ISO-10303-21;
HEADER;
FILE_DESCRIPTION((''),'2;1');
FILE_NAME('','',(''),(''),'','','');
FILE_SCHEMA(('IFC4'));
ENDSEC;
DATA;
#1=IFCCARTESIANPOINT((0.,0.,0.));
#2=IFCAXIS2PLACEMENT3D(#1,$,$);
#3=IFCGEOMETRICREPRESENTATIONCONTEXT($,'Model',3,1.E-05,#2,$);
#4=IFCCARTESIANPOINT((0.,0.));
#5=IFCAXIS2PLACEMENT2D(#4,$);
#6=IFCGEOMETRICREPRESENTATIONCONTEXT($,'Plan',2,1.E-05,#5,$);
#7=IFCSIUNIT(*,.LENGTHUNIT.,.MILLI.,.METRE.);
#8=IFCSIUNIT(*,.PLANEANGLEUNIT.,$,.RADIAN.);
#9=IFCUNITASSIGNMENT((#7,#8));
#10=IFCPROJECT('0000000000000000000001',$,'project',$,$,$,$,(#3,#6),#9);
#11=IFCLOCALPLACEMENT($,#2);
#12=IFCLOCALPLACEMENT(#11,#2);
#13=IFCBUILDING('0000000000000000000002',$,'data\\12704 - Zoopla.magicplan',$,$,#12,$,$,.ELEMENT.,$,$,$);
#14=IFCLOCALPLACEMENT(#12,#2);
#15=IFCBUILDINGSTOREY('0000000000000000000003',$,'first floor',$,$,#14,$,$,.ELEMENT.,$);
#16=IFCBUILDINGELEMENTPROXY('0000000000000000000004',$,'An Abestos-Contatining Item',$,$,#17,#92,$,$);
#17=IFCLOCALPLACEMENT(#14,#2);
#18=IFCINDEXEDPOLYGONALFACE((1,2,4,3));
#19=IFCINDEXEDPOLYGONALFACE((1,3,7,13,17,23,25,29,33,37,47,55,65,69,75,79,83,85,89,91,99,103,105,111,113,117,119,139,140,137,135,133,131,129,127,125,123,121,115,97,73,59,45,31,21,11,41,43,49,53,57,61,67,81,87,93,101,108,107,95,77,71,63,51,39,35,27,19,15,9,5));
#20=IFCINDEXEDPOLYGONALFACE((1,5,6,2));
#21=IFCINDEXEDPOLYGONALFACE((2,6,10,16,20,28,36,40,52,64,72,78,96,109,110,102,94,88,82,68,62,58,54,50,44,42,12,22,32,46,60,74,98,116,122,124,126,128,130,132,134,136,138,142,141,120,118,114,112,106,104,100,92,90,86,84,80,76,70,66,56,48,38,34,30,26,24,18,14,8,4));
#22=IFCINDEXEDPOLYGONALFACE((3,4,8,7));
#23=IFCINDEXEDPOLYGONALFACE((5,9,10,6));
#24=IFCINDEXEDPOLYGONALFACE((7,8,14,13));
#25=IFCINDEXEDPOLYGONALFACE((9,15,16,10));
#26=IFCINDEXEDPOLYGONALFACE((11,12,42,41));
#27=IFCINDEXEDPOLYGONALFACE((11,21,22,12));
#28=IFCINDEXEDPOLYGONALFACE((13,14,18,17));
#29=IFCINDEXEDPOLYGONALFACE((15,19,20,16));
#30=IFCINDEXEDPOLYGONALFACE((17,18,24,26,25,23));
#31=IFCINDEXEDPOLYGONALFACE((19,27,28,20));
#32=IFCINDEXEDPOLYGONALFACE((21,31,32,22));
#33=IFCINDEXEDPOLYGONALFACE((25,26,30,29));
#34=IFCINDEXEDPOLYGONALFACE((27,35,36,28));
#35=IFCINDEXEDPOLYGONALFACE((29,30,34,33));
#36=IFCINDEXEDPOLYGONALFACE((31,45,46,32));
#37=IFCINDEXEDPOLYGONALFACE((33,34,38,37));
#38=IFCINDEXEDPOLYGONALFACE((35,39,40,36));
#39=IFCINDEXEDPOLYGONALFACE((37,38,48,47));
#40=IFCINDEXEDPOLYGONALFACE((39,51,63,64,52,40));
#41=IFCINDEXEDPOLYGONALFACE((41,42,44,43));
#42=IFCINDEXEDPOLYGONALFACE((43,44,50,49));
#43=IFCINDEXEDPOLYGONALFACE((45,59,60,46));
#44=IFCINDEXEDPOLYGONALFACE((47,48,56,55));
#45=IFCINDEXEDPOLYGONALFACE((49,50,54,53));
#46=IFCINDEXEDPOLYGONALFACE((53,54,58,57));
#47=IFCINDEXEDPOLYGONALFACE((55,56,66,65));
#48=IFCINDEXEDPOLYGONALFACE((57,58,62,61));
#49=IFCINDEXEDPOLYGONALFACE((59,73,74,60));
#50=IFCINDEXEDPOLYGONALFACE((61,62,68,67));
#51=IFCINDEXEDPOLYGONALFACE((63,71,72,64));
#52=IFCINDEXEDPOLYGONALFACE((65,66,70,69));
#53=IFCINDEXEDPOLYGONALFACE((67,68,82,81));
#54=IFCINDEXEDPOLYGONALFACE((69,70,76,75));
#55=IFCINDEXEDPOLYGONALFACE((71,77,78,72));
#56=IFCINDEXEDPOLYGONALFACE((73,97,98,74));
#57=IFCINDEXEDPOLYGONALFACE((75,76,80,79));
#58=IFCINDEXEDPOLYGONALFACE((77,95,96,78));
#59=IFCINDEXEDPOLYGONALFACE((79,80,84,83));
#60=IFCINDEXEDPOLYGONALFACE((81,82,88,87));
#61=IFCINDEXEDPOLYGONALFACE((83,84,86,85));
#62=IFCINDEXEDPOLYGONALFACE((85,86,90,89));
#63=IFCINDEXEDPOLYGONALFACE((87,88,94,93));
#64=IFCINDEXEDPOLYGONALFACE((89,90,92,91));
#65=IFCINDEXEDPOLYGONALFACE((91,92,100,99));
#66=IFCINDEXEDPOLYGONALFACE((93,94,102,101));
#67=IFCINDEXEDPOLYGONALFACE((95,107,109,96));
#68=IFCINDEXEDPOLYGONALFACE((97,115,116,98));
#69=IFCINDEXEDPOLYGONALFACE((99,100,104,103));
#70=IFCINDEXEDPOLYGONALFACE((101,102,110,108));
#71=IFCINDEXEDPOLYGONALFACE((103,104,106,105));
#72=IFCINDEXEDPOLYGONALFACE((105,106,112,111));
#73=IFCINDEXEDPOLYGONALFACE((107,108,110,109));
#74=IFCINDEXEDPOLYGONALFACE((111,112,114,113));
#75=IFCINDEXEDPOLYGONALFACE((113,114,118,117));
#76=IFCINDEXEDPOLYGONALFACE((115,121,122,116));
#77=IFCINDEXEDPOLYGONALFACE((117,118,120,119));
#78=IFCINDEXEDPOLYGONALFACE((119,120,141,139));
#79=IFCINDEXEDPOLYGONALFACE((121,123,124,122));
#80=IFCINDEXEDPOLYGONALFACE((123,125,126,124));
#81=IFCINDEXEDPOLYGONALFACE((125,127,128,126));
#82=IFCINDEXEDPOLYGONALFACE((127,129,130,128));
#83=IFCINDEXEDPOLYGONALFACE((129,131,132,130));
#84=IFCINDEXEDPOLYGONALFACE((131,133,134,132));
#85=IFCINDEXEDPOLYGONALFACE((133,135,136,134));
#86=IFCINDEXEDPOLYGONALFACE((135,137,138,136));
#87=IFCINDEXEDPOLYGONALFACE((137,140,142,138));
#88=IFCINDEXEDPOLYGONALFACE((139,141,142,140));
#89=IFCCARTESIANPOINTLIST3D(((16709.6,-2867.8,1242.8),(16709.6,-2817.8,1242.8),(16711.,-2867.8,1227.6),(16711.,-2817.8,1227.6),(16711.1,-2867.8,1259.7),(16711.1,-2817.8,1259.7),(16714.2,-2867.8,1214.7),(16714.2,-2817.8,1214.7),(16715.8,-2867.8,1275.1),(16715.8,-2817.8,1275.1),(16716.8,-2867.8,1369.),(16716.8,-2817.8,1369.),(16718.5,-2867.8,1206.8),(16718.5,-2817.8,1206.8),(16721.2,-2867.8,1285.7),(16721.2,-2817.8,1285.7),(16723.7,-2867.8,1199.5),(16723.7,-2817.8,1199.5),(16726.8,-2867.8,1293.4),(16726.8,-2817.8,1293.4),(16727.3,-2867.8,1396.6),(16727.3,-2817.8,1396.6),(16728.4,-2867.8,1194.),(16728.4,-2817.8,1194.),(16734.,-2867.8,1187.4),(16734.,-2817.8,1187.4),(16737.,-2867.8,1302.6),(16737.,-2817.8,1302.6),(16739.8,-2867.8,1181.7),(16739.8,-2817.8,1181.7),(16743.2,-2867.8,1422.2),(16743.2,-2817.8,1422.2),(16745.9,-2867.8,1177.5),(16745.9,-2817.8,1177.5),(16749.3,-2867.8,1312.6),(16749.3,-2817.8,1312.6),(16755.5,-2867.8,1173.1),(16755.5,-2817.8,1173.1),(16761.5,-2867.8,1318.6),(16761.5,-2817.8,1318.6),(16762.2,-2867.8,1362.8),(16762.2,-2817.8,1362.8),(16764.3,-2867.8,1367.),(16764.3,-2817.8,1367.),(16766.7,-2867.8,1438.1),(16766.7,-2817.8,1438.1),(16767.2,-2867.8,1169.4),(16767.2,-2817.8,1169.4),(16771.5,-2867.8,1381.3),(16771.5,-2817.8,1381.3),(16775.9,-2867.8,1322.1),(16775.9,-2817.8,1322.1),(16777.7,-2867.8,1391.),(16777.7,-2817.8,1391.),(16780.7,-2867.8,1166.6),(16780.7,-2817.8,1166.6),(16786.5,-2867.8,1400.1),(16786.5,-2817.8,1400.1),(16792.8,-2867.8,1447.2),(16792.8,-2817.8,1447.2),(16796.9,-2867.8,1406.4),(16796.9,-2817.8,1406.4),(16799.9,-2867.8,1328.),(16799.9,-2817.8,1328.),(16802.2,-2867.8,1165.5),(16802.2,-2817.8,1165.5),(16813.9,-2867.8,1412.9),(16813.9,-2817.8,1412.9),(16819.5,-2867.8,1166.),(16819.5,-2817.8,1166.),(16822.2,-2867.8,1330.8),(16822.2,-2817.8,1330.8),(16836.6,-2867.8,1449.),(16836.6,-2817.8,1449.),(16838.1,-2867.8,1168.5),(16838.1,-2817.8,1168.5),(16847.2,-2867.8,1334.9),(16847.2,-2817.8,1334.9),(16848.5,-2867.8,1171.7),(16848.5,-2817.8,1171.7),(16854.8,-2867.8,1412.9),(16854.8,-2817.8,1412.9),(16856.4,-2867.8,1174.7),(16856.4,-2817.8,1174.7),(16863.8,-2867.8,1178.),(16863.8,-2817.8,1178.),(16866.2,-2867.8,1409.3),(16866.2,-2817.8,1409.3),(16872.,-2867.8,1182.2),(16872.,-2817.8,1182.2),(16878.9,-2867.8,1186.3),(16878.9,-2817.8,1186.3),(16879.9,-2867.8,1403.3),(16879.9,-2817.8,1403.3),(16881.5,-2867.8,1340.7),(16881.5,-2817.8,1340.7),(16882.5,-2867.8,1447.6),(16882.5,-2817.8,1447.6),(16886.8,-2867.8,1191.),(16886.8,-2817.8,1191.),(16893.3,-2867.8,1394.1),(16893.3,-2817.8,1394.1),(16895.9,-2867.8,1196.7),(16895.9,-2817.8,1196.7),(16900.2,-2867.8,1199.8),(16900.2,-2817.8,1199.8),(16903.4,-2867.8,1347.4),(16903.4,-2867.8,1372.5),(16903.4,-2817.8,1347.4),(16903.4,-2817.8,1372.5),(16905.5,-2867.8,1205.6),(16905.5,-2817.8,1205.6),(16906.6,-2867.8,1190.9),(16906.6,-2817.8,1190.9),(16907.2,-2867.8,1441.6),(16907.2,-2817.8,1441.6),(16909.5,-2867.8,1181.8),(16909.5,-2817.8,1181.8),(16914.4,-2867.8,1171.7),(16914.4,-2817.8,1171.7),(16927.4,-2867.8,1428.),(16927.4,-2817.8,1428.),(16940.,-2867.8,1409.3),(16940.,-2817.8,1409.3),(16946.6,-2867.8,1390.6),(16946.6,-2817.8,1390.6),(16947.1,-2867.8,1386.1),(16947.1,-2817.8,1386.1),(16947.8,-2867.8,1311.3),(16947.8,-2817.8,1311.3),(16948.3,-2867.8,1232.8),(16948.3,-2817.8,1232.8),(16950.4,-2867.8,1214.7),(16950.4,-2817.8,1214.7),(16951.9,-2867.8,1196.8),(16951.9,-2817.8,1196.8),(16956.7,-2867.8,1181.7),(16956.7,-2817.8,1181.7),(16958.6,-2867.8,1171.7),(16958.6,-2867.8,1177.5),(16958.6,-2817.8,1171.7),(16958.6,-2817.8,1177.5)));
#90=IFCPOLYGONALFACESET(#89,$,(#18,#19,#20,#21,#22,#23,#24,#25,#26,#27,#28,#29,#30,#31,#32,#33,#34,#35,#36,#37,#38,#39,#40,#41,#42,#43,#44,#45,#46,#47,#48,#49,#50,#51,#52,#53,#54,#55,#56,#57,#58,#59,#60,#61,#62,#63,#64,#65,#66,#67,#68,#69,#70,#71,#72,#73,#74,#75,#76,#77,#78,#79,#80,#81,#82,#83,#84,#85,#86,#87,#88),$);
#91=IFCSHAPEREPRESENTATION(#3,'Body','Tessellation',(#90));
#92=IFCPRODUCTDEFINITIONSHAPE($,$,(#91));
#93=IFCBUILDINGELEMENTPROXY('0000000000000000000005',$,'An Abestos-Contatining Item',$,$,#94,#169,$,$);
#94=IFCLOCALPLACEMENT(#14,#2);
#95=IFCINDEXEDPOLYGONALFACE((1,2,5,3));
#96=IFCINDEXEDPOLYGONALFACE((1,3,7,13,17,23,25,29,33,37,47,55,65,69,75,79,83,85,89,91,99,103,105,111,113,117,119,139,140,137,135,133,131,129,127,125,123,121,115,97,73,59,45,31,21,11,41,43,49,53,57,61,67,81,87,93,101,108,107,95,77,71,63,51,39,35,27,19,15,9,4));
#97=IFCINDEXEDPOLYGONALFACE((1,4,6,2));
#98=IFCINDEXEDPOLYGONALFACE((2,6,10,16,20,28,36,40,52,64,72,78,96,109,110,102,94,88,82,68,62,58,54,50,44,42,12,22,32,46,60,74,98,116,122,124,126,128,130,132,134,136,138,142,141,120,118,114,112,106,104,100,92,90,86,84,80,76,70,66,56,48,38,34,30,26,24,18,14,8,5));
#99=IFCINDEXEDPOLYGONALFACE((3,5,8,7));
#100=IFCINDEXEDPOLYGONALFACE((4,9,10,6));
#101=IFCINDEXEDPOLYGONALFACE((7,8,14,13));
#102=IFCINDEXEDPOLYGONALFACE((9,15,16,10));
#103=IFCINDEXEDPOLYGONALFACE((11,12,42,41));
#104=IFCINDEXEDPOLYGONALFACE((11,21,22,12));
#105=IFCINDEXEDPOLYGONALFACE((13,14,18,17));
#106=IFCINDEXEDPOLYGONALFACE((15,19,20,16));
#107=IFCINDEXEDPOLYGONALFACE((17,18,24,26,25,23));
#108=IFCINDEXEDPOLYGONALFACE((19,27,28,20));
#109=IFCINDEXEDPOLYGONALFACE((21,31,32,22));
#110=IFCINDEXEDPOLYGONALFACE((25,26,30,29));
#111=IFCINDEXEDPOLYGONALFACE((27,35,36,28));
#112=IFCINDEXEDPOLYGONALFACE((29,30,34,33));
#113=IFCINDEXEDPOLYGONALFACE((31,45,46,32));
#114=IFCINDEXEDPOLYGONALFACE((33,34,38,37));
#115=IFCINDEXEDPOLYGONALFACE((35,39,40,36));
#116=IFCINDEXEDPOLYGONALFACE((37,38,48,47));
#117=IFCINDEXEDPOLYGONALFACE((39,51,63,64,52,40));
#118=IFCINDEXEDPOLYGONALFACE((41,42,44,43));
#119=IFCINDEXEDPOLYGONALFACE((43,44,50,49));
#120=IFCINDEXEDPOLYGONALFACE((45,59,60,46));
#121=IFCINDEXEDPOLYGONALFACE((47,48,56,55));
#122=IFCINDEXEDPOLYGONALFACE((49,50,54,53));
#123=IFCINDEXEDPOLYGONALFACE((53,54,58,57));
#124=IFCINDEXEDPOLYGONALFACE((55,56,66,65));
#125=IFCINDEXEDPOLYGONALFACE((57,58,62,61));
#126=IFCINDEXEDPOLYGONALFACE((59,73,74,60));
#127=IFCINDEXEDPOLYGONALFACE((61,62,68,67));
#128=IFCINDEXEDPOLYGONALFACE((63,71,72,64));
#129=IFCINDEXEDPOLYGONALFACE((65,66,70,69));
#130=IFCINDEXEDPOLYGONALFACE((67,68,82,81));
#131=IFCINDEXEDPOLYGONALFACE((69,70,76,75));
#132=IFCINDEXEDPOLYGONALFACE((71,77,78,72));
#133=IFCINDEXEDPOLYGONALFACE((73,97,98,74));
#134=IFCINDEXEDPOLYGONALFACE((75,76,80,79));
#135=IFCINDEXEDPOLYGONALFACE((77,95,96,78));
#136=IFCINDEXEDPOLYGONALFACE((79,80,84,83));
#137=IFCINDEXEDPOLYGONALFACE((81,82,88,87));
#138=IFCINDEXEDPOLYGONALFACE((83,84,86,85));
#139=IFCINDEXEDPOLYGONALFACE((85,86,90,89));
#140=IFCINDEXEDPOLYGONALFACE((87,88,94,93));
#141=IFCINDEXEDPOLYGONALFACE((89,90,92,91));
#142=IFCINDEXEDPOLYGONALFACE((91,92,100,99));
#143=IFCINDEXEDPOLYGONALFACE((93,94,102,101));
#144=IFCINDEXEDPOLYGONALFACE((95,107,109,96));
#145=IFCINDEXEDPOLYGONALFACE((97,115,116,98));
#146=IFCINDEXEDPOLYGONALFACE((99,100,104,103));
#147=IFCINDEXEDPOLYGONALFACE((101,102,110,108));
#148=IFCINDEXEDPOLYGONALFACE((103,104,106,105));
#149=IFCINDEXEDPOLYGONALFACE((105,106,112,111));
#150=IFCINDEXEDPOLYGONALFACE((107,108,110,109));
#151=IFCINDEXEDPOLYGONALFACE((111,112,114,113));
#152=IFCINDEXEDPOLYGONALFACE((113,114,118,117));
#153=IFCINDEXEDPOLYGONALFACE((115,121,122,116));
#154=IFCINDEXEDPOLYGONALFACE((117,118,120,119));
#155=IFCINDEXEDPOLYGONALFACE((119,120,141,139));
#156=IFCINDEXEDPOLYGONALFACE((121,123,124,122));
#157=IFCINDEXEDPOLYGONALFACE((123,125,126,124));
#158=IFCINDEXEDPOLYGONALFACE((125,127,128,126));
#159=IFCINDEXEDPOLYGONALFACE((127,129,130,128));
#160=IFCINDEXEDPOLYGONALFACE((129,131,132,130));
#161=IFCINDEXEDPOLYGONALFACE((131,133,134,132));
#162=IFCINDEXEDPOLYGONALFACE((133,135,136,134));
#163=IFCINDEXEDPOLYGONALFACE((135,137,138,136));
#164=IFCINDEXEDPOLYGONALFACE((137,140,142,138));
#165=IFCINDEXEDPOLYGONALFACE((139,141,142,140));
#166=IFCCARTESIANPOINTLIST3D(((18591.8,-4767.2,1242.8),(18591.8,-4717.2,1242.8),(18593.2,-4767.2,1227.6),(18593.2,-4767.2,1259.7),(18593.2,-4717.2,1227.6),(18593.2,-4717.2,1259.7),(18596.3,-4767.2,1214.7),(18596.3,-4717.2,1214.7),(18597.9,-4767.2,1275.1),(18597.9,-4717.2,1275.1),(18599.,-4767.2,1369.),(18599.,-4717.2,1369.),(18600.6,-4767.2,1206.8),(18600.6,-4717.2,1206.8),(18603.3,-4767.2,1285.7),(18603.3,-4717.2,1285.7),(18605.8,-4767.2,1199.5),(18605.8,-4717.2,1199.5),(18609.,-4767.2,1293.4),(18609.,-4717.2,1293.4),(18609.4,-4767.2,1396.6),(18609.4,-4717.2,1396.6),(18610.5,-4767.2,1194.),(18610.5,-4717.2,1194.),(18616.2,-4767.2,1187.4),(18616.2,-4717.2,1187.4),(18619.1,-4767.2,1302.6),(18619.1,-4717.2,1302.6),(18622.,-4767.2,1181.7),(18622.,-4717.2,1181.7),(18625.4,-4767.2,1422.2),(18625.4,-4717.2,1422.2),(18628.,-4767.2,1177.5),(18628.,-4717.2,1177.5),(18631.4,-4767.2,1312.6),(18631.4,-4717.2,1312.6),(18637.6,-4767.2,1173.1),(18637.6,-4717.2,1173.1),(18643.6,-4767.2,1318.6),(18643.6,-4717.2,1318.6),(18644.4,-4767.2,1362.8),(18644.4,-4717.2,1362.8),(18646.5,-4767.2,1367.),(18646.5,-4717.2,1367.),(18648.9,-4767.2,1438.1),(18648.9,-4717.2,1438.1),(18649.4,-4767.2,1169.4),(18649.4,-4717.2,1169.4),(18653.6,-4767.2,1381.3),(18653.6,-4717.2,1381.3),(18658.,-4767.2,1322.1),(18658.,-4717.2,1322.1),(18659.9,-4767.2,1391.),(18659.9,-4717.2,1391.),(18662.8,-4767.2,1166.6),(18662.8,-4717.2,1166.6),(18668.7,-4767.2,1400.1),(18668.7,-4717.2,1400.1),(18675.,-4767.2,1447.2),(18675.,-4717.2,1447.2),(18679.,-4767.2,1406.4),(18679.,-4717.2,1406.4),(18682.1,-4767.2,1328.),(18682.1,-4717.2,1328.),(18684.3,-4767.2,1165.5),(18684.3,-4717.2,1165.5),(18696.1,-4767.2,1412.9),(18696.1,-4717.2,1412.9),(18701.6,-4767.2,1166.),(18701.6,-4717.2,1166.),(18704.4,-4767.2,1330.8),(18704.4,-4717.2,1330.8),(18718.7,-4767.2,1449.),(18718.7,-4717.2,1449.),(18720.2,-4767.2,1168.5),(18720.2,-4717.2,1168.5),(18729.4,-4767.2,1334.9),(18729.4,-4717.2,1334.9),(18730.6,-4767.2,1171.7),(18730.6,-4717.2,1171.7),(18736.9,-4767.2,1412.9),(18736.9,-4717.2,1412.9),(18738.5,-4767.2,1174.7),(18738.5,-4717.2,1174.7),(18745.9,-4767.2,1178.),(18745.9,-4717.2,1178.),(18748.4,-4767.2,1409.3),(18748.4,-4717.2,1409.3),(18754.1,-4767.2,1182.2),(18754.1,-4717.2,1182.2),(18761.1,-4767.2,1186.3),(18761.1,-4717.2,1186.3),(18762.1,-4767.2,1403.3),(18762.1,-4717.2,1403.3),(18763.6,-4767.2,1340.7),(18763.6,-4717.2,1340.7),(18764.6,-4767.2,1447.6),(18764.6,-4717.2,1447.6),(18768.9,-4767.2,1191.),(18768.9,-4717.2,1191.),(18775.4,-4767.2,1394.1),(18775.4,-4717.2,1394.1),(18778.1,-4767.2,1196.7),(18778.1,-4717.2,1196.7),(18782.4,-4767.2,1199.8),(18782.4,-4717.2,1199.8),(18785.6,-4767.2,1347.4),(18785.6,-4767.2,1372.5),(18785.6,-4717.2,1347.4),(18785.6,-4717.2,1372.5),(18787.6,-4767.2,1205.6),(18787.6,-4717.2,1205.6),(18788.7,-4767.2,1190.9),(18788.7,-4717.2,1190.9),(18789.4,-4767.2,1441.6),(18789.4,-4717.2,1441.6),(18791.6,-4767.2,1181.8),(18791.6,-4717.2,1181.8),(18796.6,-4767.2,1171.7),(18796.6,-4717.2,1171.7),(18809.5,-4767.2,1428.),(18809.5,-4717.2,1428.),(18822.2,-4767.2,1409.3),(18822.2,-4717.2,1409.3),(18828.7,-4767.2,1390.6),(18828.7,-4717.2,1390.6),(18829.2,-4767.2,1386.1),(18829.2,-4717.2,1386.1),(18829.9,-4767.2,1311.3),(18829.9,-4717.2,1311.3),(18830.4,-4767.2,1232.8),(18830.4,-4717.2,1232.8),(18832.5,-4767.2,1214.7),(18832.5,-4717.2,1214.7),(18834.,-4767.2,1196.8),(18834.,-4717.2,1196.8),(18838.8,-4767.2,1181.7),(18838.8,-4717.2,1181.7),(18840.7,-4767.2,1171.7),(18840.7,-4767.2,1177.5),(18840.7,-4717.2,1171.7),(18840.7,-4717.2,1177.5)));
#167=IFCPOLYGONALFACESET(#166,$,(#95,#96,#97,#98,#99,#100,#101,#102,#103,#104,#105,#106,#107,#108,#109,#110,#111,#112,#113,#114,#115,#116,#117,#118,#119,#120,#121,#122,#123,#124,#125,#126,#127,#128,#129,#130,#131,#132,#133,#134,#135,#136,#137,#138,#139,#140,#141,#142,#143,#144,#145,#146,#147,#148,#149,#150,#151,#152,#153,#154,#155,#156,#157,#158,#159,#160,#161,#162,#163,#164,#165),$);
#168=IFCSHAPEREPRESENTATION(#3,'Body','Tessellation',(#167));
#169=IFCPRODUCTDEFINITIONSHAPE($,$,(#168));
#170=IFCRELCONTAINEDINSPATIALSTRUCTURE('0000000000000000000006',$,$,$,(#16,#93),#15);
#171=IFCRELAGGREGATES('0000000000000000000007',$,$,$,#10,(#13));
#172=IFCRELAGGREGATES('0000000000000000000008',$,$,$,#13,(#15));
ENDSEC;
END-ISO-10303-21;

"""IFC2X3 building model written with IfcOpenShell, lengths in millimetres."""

from ifc_helpers import new_model, si_unit, frame, origin, origin_2d, place, context, project, spatial, polyline, outline, extrude, element, save


model = new_model("IFC2X3")

# Units and contexts
model_context = context("Model", 3, precision=1e-05, world=origin())
plan_context = context("Plan", 2, precision=1e-05, world=origin_2d())
ifc_project = project(units=[si_unit("LENGTHUNIT", "METRE", prefix="MILLI"), si_unit("PLANEANGLEUNIT", "RADIAN")], contexts=[model_context, plan_context])

# Building, storey
placement_1 = place(None, origin())
building_placement = place(placement_1, origin())
building = spatial("IfcBuilding", under=ifc_project, at=building_placement, Name="data\\12704 - Zoopla.magicplan", CompositionType="ELEMENT")
storey_placement = place(building_placement, origin())
storey = spatial("IfcBuildingStorey", under=building, at=storey_placement, Name="first floor", CompositionType="ELEMENT")

# Building element proxies
placement_2 = place(None, frame((17468.6, -3594.3, 0.0)))
proxy_1_placement = place(placement_2, frame((-760.0, 776.6, 1165.0)))
element("IfcBuildingElementProxy", 1, at=proxy_1_placement, inside=storey, Name="An Abestos-Contatining Item", context=model_context, shape_type="SurfaceModel", body=[
    extrude(outline(polyline([(239.2, 0.0, 146.3), (239.7, 0.0, 67.8), (241.8, 0.0, 49.7), (243.3, 0.0, 31.9), (248.1, 0.0, 16.7), (250.0, 0.0, 12.5), (250.0, 0.0, 6.7), (205.8, 0.0, 6.7), (200.9, 0.0, 16.8), (197.9, 0.0, 25.9), (196.9, 0.0, 40.6), (191.6, 0.0, 34.8), (187.3, 0.0, 31.7), (178.2, 0.0, 26.0), (170.3, 0.0, 21.3), (163.4, 0.0, 17.2), (155.2, 0.0, 13.0), (147.8, 0.0, 9.7), (139.9, 0.0, 6.7), (129.5, 0.0, 3.5), (110.9, 0.0, 1.0), (93.6, 0.0, 0.5), (72.1, 0.0, 1.6), (58.6, 0.0, 4.4), (46.9, 0.0, 8.1), (37.3, 0.0, 12.5), (31.2, 0.0, 16.7), (25.4, 0.0, 22.4), (19.8, 0.0, 29.0), (15.1, 0.0, 34.5), (9.9, 0.0, 41.9), (5.5, 0.0, 49.7), (2.5, 0.0, 62.6), (1.0, 0.0, 77.8), (2.5, 0.0, 94.7), (7.2, 0.0, 110.1), (12.6, 0.0, 120.7), (18.2, 0.0, 128.4), (28.4, 0.0, 137.6), (40.7, 0.0, 147.6), (52.9, 0.0, 153.6), (67.3, 0.0, 157.1), (91.3, 0.0, 163.0), (113.7, 0.0, 165.8), (138.6, 0.0, 169.9), (172.9, 0.0, 175.7), (194.8, 0.0, 182.4), (194.8, 0.0, 207.5), (184.7, 0.0, 229.1), (171.3, 0.0, 238.3), (157.6, 0.0, 244.3), (146.2, 0.0, 247.9), (105.3, 0.0, 247.9), (88.3, 0.0, 241.4), (77.9, 0.0, 235.1), (69.1, 0.0, 226.0), (62.9, 0.0, 216.3), (55.7, 0.0, 202.0), (53.6, 0.0, 197.8), (8.2, 0.0, 204.0), (18.7, 0.0, 231.7), (34.6, 0.0, 257.2), (58.1, 0.0, 273.1), (84.2, 0.0, 282.2), (128.0, 0.0, 284.0), (173.9, 0.0, 282.6), (198.6, 0.0, 276.6), (218.8, 0.0, 263.1), (231.4, 0.0, 244.3), (238.0, 0.0, 225.6), (238.5, 0.0, 221.1)]), holes=[polyline([(193.0, 0.0, 144.2), (193.0, 0.0, 117.7), (190.5, 0.0, 97.8), (183.8, 0.0, 80.4), (174.2, 0.0, 64.5), (165.3, 0.0, 54.4), (152.5, 0.0, 47.3), (138.0, 0.0, 41.5), (124.6, 0.0, 37.8), (85.5, 0.0, 37.8), (75.0, 0.0, 41.4), (65.8, 0.0, 47.1), (57.8, 0.0, 55.4), (52.1, 0.0, 66.4), (49.5, 0.0, 74.4), (49.5, 0.0, 88.6), (55.3, 0.0, 100.7), (65.3, 0.0, 109.9), (81.0, 0.0, 119.8), (101.0, 0.0, 125.3), (119.9, 0.0, 128.5), (146.8, 0.0, 131.5), (165.0, 0.0, 134.9), (179.8, 0.0, 140.1), (193.0, 0.0, 144.2)])], kind="CURVE"), origin(), (0.0, -1.0, 0.0), 50.0),
])
placement_3 = place(None, frame((17468.6, -3594.3, 0.0)))
proxy_2_placement = place(placement_3, frame((1122.2, -1122.9, 1165.0)))
element("IfcBuildingElementProxy", 2, at=proxy_2_placement, inside=storey, Name="An Abestos-Contatining Item", context=model_context, shape_type="SurfaceModel", body=[
    extrude(outline(polyline([(239.2, 0.0, 146.3), (239.7, 0.0, 67.8), (241.8, 0.0, 49.7), (243.3, 0.0, 31.9), (248.1, 0.0, 16.7), (250.0, 0.0, 12.5), (250.0, 0.0, 6.7), (205.8, 0.0, 6.7), (200.9, 0.0, 16.8), (197.9, 0.0, 25.9), (196.9, 0.0, 40.6), (191.6, 0.0, 34.8), (187.3, 0.0, 31.7), (178.2, 0.0, 26.0), (170.3, 0.0, 21.3), (163.4, 0.0, 17.2), (155.2, 0.0, 13.0), (147.8, 0.0, 9.7), (139.9, 0.0, 6.7), (129.5, 0.0, 3.5), (110.9, 0.0, 1.0), (93.6, 0.0, 0.5), (72.1, 0.0, 1.6), (58.6, 0.0, 4.4), (46.9, 0.0, 8.1), (37.3, 0.0, 12.5), (31.2, 0.0, 16.7), (25.4, 0.0, 22.4), (19.8, 0.0, 29.0), (15.1, 0.0, 34.5), (9.9, 0.0, 41.9), (5.5, 0.0, 49.7), (2.5, 0.0, 62.6), (1.0, 0.0, 77.8), (2.5, 0.0, 94.7), (7.2, 0.0, 110.1), (12.6, 0.0, 120.7), (18.2, 0.0, 128.4), (28.4, 0.0, 137.6), (40.7, 0.0, 147.6), (52.9, 0.0, 153.6), (67.3, 0.0, 157.1), (91.3, 0.0, 163.0), (113.7, 0.0, 165.8), (138.6, 0.0, 169.9), (172.9, 0.0, 175.7), (194.8, 0.0, 182.4), (194.8, 0.0, 207.5), (184.7, 0.0, 229.1), (171.3, 0.0, 238.3), (157.6, 0.0, 244.3), (146.2, 0.0, 247.9), (105.3, 0.0, 247.9), (88.3, 0.0, 241.4), (77.9, 0.0, 235.1), (69.1, 0.0, 226.0), (62.9, 0.0, 216.3), (55.7, 0.0, 202.0), (53.6, 0.0, 197.8), (8.2, 0.0, 204.0), (18.7, 0.0, 231.7), (34.6, 0.0, 257.2), (58.1, 0.0, 273.1), (84.2, 0.0, 282.2), (128.0, 0.0, 284.0), (173.9, 0.0, 282.6), (198.6, 0.0, 276.6), (218.8, 0.0, 263.1), (231.4, 0.0, 244.3), (238.0, 0.0, 225.6), (238.5, 0.0, 221.1)]), holes=[polyline([(193.0, 0.0, 144.2), (193.0, 0.0, 117.7), (190.5, 0.0, 97.8), (183.8, 0.0, 80.4), (174.2, 0.0, 64.5), (165.3, 0.0, 54.4), (152.5, 0.0, 47.3), (138.0, 0.0, 41.5), (124.6, 0.0, 37.8), (85.5, 0.0, 37.8), (75.0, 0.0, 41.4), (65.8, 0.0, 47.1), (57.8, 0.0, 55.4), (52.1, 0.0, 66.4), (49.5, 0.0, 74.4), (49.5, 0.0, 88.6), (55.3, 0.0, 100.7), (65.3, 0.0, 109.9), (81.0, 0.0, 119.8), (101.0, 0.0, 125.3), (119.9, 0.0, 128.5), (146.8, 0.0, 131.5), (165.0, 0.0, 134.9), (179.8, 0.0, 140.1), (193.0, 0.0, 144.2)])], kind="CURVE"), origin(), (0.0, -1.0, 0.0), 50.0),
])

save(model, "model.ifc")
